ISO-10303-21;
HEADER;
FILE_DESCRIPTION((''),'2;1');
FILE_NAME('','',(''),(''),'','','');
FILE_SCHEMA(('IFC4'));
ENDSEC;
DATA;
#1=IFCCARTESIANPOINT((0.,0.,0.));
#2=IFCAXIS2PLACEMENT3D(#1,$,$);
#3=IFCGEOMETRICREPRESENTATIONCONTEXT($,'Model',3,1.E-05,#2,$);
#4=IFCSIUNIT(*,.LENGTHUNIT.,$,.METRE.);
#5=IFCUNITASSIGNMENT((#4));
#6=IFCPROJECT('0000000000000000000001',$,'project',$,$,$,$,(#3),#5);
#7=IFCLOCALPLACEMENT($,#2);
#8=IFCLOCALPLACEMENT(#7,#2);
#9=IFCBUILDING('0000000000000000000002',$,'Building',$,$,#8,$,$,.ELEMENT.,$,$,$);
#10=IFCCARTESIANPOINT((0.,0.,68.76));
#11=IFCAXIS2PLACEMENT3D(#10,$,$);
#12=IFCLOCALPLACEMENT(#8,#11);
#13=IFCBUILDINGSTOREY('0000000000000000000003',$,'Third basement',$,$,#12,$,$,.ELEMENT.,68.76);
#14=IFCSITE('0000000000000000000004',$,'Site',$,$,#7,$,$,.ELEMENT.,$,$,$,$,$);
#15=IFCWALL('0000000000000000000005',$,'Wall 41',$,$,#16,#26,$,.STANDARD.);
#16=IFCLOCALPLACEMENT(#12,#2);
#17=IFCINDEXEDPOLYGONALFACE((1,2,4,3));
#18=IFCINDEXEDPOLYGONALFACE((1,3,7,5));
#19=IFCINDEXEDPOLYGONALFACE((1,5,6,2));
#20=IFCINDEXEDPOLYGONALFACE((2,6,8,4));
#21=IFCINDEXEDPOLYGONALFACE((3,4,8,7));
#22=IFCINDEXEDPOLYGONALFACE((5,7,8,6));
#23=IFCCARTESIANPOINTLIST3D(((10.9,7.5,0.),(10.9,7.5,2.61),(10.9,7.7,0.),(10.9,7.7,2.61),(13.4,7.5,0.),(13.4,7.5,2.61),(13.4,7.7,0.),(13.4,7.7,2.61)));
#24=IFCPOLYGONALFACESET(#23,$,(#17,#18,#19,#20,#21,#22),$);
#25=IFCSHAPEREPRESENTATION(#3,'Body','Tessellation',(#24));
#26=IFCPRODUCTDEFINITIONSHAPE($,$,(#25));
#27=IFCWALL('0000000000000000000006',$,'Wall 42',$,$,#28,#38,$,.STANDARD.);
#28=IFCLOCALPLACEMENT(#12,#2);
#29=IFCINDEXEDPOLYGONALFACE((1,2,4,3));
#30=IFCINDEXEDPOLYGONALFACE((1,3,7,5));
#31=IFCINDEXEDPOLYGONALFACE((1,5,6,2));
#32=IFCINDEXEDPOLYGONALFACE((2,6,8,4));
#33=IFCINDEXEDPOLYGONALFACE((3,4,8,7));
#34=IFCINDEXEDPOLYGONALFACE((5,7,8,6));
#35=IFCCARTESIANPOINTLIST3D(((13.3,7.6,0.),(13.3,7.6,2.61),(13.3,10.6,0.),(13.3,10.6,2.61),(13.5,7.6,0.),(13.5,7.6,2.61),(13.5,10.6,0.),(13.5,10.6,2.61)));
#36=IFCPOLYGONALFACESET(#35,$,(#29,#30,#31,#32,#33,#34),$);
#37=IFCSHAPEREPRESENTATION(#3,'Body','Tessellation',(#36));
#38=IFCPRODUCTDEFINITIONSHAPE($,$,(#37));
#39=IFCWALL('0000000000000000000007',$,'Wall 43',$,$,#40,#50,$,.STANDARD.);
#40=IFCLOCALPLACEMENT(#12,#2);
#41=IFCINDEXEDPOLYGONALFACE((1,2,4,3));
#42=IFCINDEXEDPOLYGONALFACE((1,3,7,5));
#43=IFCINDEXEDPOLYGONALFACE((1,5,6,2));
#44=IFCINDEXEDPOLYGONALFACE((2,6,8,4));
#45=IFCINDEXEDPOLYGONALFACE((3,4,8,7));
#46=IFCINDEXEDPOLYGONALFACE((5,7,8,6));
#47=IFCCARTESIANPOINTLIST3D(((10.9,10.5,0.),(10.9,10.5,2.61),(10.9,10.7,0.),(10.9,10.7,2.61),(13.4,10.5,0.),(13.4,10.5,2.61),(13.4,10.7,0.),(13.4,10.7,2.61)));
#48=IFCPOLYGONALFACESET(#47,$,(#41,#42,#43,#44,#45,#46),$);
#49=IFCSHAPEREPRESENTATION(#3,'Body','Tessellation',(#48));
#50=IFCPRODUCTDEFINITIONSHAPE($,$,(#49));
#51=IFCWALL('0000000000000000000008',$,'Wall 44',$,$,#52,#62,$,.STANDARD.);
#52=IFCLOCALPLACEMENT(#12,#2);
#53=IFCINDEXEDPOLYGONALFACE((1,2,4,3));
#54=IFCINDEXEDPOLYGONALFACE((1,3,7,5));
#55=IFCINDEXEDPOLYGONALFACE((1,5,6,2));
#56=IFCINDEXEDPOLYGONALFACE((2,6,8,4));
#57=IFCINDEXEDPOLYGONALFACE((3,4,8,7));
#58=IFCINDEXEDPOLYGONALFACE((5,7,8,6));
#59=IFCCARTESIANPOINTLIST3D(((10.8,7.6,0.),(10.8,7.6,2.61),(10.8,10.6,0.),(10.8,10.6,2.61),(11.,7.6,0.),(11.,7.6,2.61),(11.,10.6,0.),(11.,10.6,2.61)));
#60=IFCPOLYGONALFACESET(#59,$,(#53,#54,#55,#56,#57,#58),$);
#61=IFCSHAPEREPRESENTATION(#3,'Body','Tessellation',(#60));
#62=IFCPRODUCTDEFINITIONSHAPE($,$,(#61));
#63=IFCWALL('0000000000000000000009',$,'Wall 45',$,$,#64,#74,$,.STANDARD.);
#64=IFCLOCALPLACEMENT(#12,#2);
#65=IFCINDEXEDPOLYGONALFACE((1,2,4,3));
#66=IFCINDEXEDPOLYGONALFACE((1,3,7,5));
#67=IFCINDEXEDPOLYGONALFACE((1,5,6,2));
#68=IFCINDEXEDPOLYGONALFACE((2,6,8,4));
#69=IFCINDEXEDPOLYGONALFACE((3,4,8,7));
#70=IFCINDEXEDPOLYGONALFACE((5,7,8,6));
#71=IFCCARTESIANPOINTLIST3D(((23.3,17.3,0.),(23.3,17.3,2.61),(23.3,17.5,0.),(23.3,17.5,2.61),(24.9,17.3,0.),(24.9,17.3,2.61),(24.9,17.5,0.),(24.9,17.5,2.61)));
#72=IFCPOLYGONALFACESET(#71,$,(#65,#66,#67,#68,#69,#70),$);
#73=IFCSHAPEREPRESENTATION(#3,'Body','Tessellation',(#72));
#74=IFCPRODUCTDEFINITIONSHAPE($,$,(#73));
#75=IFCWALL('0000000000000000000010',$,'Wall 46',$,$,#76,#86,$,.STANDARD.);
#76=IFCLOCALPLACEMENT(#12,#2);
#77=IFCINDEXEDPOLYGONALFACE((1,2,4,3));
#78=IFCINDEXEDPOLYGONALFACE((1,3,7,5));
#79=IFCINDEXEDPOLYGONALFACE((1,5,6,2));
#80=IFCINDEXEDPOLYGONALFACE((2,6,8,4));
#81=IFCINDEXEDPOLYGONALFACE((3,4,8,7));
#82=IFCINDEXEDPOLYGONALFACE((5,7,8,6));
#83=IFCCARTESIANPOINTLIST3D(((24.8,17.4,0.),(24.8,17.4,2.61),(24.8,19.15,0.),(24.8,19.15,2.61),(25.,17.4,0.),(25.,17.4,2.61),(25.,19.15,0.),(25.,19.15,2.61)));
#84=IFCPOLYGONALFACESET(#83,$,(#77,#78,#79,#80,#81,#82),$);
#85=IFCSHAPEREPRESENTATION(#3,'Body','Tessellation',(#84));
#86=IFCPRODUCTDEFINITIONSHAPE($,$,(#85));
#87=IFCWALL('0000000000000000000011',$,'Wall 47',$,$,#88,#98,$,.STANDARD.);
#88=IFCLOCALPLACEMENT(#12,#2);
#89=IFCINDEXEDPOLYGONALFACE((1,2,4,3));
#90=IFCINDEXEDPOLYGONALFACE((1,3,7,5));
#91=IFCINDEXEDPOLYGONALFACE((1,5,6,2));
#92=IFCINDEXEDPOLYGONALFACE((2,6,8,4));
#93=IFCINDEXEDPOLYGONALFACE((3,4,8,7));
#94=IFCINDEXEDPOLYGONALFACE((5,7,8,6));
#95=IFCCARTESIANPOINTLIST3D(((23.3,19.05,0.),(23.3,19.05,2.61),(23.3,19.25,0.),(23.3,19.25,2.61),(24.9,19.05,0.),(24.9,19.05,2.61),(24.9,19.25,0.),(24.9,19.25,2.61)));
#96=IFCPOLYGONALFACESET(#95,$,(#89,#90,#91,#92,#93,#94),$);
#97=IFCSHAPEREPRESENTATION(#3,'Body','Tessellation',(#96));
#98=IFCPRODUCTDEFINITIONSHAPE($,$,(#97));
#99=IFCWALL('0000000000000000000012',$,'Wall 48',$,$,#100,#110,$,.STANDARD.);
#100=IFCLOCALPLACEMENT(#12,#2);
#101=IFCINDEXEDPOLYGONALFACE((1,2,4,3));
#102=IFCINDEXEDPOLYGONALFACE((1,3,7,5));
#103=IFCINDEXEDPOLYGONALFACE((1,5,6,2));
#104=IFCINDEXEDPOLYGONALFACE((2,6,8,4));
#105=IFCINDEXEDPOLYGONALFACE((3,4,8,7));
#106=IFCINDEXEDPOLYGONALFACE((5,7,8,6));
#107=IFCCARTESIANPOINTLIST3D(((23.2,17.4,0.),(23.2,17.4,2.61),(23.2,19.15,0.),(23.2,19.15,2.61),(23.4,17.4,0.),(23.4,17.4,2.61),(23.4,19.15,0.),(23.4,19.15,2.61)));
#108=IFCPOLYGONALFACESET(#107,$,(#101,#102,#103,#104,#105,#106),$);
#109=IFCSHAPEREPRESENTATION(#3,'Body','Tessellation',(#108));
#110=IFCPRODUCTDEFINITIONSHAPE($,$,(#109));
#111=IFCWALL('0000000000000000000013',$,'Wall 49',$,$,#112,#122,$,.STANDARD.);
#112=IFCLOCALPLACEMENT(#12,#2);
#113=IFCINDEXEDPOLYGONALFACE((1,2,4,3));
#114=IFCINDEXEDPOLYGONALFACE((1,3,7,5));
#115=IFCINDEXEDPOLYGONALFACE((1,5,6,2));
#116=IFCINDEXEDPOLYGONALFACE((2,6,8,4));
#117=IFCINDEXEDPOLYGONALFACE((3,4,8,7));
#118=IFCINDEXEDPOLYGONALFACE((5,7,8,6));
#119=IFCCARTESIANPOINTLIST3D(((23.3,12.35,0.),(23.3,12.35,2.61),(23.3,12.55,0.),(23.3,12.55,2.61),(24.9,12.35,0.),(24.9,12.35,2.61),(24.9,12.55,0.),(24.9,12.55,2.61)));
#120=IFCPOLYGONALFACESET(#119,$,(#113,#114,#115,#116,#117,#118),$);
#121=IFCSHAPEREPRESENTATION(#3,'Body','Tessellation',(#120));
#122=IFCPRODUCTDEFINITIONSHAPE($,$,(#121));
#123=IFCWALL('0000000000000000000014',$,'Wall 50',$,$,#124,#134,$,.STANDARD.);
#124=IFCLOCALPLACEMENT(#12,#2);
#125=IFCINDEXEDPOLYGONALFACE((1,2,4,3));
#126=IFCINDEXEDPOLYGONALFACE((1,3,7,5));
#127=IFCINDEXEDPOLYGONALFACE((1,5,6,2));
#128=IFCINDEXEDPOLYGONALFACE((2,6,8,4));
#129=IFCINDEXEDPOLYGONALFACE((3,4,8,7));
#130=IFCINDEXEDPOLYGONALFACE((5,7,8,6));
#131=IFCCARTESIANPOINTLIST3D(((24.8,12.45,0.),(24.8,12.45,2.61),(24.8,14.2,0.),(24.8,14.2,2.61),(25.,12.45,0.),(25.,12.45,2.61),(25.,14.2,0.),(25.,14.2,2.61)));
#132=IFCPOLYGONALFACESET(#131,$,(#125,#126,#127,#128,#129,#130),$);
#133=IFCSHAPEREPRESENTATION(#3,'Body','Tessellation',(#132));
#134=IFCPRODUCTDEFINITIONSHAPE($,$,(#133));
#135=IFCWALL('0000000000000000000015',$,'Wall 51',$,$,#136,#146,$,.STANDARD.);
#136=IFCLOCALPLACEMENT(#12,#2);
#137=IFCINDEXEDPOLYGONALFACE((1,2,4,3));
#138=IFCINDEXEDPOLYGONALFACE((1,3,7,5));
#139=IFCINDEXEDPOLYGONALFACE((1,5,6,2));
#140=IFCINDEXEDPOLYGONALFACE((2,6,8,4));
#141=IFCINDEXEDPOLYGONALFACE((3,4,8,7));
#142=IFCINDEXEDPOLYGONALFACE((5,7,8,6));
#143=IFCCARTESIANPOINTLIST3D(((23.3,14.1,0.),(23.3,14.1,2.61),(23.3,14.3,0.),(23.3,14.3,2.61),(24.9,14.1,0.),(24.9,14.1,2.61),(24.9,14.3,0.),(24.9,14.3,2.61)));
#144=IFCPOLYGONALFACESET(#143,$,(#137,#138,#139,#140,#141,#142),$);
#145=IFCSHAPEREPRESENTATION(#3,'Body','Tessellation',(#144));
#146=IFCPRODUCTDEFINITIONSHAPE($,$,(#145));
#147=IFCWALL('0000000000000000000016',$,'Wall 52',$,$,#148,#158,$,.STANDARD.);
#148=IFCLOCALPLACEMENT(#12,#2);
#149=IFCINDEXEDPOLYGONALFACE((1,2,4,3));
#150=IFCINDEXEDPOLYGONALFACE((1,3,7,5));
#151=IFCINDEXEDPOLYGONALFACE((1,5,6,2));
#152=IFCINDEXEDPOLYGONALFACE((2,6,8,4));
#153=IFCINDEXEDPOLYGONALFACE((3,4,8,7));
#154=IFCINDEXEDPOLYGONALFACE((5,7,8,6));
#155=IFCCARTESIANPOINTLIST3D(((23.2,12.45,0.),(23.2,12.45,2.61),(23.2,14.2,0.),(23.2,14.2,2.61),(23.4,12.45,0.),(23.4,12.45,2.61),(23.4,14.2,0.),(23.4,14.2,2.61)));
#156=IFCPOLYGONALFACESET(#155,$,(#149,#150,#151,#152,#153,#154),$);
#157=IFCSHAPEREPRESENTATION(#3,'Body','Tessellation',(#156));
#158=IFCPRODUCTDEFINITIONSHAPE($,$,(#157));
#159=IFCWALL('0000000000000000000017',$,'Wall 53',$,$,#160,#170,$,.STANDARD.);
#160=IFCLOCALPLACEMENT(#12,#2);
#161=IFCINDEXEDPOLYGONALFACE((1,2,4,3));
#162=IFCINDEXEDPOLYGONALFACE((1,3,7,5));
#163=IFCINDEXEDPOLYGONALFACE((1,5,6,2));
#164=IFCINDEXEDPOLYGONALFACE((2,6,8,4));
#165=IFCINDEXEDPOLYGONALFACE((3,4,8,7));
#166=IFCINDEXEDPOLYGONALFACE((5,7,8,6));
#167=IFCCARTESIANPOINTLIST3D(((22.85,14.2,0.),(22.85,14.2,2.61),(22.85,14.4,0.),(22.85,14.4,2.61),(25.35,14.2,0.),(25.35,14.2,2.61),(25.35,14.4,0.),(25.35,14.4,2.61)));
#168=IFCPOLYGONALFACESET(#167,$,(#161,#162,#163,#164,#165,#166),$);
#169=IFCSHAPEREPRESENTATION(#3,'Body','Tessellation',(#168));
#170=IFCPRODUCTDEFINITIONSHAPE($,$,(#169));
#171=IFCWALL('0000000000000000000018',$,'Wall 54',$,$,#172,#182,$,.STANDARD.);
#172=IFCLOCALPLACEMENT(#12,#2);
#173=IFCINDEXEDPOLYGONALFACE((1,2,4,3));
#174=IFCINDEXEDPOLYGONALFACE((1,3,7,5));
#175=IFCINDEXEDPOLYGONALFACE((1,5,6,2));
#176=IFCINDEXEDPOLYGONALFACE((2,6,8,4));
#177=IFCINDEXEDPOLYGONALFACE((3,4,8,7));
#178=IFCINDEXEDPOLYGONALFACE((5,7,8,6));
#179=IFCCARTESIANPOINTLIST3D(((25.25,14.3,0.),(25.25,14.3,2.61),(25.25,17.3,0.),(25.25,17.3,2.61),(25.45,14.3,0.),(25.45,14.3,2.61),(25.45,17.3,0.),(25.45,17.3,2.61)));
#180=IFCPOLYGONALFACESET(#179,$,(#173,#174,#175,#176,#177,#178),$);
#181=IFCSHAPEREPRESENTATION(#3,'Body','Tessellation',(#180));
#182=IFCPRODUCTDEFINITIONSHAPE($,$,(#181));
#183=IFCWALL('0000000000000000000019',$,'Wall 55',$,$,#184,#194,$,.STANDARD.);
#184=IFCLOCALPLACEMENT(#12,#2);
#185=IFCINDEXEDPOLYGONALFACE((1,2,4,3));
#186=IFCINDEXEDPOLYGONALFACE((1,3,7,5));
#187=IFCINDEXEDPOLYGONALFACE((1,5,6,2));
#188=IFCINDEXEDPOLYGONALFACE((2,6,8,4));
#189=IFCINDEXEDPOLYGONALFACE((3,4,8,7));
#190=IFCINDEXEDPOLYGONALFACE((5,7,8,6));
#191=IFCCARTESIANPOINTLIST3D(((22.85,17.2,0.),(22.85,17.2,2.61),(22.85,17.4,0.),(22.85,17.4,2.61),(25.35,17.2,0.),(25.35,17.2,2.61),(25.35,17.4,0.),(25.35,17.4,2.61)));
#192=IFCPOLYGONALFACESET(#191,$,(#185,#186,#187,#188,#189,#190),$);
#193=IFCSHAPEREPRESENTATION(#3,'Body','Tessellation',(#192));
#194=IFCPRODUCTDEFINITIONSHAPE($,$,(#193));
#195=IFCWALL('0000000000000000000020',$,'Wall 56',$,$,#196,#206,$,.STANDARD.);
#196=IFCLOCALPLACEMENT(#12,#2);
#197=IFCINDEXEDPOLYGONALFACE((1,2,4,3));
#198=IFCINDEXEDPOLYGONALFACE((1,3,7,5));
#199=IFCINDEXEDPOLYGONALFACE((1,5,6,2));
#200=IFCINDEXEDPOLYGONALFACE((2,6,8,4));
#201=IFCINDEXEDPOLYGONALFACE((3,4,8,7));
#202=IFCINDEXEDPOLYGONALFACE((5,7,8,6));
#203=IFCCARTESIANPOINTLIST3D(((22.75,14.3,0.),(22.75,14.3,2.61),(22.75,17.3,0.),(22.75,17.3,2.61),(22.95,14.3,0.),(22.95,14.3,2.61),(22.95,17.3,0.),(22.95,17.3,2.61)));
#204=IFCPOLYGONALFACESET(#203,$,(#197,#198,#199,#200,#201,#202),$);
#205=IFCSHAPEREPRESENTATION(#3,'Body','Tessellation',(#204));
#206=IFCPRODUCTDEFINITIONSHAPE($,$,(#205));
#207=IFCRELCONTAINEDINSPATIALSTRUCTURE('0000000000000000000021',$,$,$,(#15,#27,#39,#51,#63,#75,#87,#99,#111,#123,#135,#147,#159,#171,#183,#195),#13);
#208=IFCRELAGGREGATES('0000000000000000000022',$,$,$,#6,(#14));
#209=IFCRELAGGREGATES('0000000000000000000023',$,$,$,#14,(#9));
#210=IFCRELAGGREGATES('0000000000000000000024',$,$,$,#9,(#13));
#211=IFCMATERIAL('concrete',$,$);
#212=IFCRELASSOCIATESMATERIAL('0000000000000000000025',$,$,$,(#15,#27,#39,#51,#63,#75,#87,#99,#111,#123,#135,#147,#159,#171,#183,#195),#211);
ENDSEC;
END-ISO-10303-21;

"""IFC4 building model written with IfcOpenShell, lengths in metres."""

from ifc_helpers import new_model, si_unit, frame, frame_2d, origin, place, context, project, spatial, rectangle, extrude, material, element, save


model = new_model("IFC4")

# Units and contexts
model_context = context("Model", 3, precision=1e-05, world=origin())
ifc_project = project(units=[si_unit("LENGTHUNIT", "METRE")], contexts=[model_context])

# Site, building, storey
site_placement = place(None, origin())
site = spatial("IfcSite", under=ifc_project, at=site_placement, Name="Site", CompositionType="ELEMENT")
building_placement = place(site_placement, origin())
building = spatial("IfcBuilding", under=site, at=building_placement, Name="Building", CompositionType="ELEMENT")
storey_placement = place(building_placement, frame((0.0, 0.0, 68.76)))
storey = spatial("IfcBuildingStorey", under=building, at=storey_placement, Name="Third basement", CompositionType="ELEMENT", Elevation=68.76)

# Shared definitions
ifc_material = material(Name="concrete")

# Walls
wall_1_placement = place(storey_placement, frame((10.9, 7.6, 0.0), z_axis=(0.0, 0.0, 1.0), x_axis=(1.0, 0.0, 0.0)))
element("IfcWall", 1, at=wall_1_placement, inside=storey, material=ifc_material, Name="Wall 41", PredefinedType="STANDARD", context=model_context, shape_type="SweptSolid", body=[
    extrude(rectangle(XDim=2.5, YDim=0.2, at=frame_2d((1.25, 0.0))), origin(), (0.0, 0.0, 1.0), 2.61),
])
wall_2_placement = place(storey_placement, frame((13.4, 7.6, 0.0), z_axis=(0.0, 0.0, 1.0), x_axis=(0.0, 1.0, 0.0)))
element("IfcWall", 2, at=wall_2_placement, inside=storey, material=ifc_material, Name="Wall 42", PredefinedType="STANDARD", context=model_context, shape_type="SweptSolid", body=[
    extrude(rectangle(XDim=3.0, YDim=0.2, at=frame_2d((1.5, 0.0))), origin(), (0.0, 0.0, 1.0), 2.61),
])
wall_3_placement = place(storey_placement, frame((13.4, 10.6, 0.0), z_axis=(0.0, 0.0, 1.0), x_axis=(-1.0, 0.0, 0.0)))
element("IfcWall", 3, at=wall_3_placement, inside=storey, material=ifc_material, Name="Wall 43", PredefinedType="STANDARD", context=model_context, shape_type="SweptSolid", body=[
    extrude(rectangle(XDim=2.5, YDim=0.2, at=frame_2d((1.25, 0.0))), origin(), (0.0, 0.0, 1.0), 2.61),
])
wall_4_placement = place(storey_placement, frame((10.9, 10.6, 0.0), z_axis=(0.0, 0.0, 1.0), x_axis=(0.0, -1.0, 0.0)))
element("IfcWall", 4, at=wall_4_placement, inside=storey, material=ifc_material, Name="Wall 44", PredefinedType="STANDARD", context=model_context, shape_type="SweptSolid", body=[
    extrude(rectangle(XDim=3.0, YDim=0.2, at=frame_2d((1.5, 0.0))), origin(), (0.0, 0.0, 1.0), 2.61),
])
wall_5_placement = place(storey_placement, frame((23.3, 17.4, 0.0), z_axis=(0.0, 0.0, 1.0), x_axis=(1.0, 0.0, 0.0)))
element("IfcWall", 5, at=wall_5_placement, inside=storey, material=ifc_material, Name="Wall 45", PredefinedType="STANDARD", context=model_context, shape_type="SweptSolid", body=[
    extrude(rectangle(XDim=1.6, YDim=0.2, at=frame_2d((0.8, 0.0))), origin(), (0.0, 0.0, 1.0), 2.61),
])
wall_6_placement = place(storey_placement, frame((24.9, 17.4, 0.0), z_axis=(0.0, 0.0, 1.0), x_axis=(0.0, 1.0, 0.0)))
element("IfcWall", 6, at=wall_6_placement, inside=storey, material=ifc_material, Name="Wall 46", PredefinedType="STANDARD", context=model_context, shape_type="SweptSolid", body=[
    extrude(rectangle(XDim=1.75, YDim=0.2, at=frame_2d((0.875, 0.0))), origin(), (0.0, 0.0, 1.0), 2.61),
])
wall_7_placement = place(storey_placement, frame((24.9, 19.15, 0.0), z_axis=(0.0, 0.0, 1.0), x_axis=(-1.0, 0.0, 0.0)))
element("IfcWall", 7, at=wall_7_placement, inside=storey, material=ifc_material, Name="Wall 47", PredefinedType="STANDARD", context=model_context, shape_type="SweptSolid", body=[
    extrude(rectangle(XDim=1.6, YDim=0.2, at=frame_2d((0.8, 0.0))), origin(), (0.0, 0.0, 1.0), 2.61),
])
wall_8_placement = place(storey_placement, frame((23.3, 19.15, 0.0), z_axis=(0.0, 0.0, 1.0), x_axis=(0.0, -1.0, 0.0)))
element("IfcWall", 8, at=wall_8_placement, inside=storey, material=ifc_material, Name="Wall 48", PredefinedType="STANDARD", context=model_context, shape_type="SweptSolid", body=[
    extrude(rectangle(XDim=1.75, YDim=0.2, at=frame_2d((0.875, 0.0))), origin(), (0.0, 0.0, 1.0), 2.61),
])
wall_9_placement = place(storey_placement, frame((23.3, 12.45, 0.0), z_axis=(0.0, 0.0, 1.0), x_axis=(1.0, 0.0, 0.0)))
element("IfcWall", 9, at=wall_9_placement, inside=storey, material=ifc_material, Name="Wall 49", PredefinedType="STANDARD", context=model_context, shape_type="SweptSolid", body=[
    extrude(rectangle(XDim=1.6, YDim=0.2, at=frame_2d((0.8, 0.0))), origin(), (0.0, 0.0, 1.0), 2.61),
])
wall_10_placement = place(storey_placement, frame((24.9, 12.45, 0.0), z_axis=(0.0, 0.0, 1.0), x_axis=(0.0, 1.0, 0.0)))
element("IfcWall", 10, at=wall_10_placement, inside=storey, material=ifc_material, Name="Wall 50", PredefinedType="STANDARD", context=model_context, shape_type="SweptSolid", body=[
    extrude(rectangle(XDim=1.75, YDim=0.2, at=frame_2d((0.875, 0.0))), origin(), (0.0, 0.0, 1.0), 2.61),
])
wall_11_placement = place(storey_placement, frame((24.9, 14.2, 0.0), z_axis=(0.0, 0.0, 1.0), x_axis=(-1.0, 0.0, 0.0)))
element("IfcWall", 11, at=wall_11_placement, inside=storey, material=ifc_material, Name="Wall 51", PredefinedType="STANDARD", context=model_context, shape_type="SweptSolid", body=[
    extrude(rectangle(XDim=1.6, YDim=0.2, at=frame_2d((0.8, 0.0))), origin(), (0.0, 0.0, 1.0), 2.61),
])
wall_12_placement = place(storey_placement, frame((23.3, 14.2, 0.0), z_axis=(0.0, 0.0, 1.0), x_axis=(0.0, -1.0, 0.0)))
element("IfcWall", 12, at=wall_12_placement, inside=storey, material=ifc_material, Name="Wall 52", PredefinedType="STANDARD", context=model_context, shape_type="SweptSolid", body=[
    extrude(rectangle(XDim=1.75, YDim=0.2, at=frame_2d((0.875, 0.0))), origin(), (0.0, 0.0, 1.0), 2.61),
])
wall_13_placement = place(storey_placement, frame((22.85, 14.3, 0.0), z_axis=(0.0, 0.0, 1.0), x_axis=(1.0, 0.0, 0.0)))
element("IfcWall", 13, at=wall_13_placement, inside=storey, material=ifc_material, Name="Wall 53", PredefinedType="STANDARD", context=model_context, shape_type="SweptSolid", body=[
    extrude(rectangle(XDim=2.5, YDim=0.2, at=frame_2d((1.25, 0.0))), origin(), (0.0, 0.0, 1.0), 2.61),
])
wall_14_placement = place(storey_placement, frame((25.35, 14.3, 0.0), z_axis=(0.0, 0.0, 1.0), x_axis=(0.0, 1.0, 0.0)))
element("IfcWall", 14, at=wall_14_placement, inside=storey, material=ifc_material, Name="Wall 54", PredefinedType="STANDARD", context=model_context, shape_type="SweptSolid", body=[
    extrude(rectangle(XDim=3.0, YDim=0.2, at=frame_2d((1.5, 0.0))), origin(), (0.0, 0.0, 1.0), 2.61),
])
wall_15_placement = place(storey_placement, frame((25.35, 17.3, 0.0), z_axis=(0.0, 0.0, 1.0), x_axis=(-1.0, 0.0, 0.0)))
element("IfcWall", 15, at=wall_15_placement, inside=storey, material=ifc_material, Name="Wall 55", PredefinedType="STANDARD", context=model_context, shape_type="SweptSolid", body=[
    extrude(rectangle(XDim=2.5, YDim=0.2, at=frame_2d((1.25, 0.0))), origin(), (0.0, 0.0, 1.0), 2.61),
])
wall_16_placement = place(storey_placement, frame((22.85, 17.3, 0.0), z_axis=(0.0, 0.0, 1.0), x_axis=(0.0, -1.0, 0.0)))
element("IfcWall", 16, at=wall_16_placement, inside=storey, material=ifc_material, Name="Wall 56", PredefinedType="STANDARD", context=model_context, shape_type="SweptSolid", body=[
    extrude(rectangle(XDim=3.0, YDim=0.2, at=frame_2d((1.5, 0.0))), origin(), (0.0, 0.0, 1.0), 2.61),
])

save(model, "model.ifc")
